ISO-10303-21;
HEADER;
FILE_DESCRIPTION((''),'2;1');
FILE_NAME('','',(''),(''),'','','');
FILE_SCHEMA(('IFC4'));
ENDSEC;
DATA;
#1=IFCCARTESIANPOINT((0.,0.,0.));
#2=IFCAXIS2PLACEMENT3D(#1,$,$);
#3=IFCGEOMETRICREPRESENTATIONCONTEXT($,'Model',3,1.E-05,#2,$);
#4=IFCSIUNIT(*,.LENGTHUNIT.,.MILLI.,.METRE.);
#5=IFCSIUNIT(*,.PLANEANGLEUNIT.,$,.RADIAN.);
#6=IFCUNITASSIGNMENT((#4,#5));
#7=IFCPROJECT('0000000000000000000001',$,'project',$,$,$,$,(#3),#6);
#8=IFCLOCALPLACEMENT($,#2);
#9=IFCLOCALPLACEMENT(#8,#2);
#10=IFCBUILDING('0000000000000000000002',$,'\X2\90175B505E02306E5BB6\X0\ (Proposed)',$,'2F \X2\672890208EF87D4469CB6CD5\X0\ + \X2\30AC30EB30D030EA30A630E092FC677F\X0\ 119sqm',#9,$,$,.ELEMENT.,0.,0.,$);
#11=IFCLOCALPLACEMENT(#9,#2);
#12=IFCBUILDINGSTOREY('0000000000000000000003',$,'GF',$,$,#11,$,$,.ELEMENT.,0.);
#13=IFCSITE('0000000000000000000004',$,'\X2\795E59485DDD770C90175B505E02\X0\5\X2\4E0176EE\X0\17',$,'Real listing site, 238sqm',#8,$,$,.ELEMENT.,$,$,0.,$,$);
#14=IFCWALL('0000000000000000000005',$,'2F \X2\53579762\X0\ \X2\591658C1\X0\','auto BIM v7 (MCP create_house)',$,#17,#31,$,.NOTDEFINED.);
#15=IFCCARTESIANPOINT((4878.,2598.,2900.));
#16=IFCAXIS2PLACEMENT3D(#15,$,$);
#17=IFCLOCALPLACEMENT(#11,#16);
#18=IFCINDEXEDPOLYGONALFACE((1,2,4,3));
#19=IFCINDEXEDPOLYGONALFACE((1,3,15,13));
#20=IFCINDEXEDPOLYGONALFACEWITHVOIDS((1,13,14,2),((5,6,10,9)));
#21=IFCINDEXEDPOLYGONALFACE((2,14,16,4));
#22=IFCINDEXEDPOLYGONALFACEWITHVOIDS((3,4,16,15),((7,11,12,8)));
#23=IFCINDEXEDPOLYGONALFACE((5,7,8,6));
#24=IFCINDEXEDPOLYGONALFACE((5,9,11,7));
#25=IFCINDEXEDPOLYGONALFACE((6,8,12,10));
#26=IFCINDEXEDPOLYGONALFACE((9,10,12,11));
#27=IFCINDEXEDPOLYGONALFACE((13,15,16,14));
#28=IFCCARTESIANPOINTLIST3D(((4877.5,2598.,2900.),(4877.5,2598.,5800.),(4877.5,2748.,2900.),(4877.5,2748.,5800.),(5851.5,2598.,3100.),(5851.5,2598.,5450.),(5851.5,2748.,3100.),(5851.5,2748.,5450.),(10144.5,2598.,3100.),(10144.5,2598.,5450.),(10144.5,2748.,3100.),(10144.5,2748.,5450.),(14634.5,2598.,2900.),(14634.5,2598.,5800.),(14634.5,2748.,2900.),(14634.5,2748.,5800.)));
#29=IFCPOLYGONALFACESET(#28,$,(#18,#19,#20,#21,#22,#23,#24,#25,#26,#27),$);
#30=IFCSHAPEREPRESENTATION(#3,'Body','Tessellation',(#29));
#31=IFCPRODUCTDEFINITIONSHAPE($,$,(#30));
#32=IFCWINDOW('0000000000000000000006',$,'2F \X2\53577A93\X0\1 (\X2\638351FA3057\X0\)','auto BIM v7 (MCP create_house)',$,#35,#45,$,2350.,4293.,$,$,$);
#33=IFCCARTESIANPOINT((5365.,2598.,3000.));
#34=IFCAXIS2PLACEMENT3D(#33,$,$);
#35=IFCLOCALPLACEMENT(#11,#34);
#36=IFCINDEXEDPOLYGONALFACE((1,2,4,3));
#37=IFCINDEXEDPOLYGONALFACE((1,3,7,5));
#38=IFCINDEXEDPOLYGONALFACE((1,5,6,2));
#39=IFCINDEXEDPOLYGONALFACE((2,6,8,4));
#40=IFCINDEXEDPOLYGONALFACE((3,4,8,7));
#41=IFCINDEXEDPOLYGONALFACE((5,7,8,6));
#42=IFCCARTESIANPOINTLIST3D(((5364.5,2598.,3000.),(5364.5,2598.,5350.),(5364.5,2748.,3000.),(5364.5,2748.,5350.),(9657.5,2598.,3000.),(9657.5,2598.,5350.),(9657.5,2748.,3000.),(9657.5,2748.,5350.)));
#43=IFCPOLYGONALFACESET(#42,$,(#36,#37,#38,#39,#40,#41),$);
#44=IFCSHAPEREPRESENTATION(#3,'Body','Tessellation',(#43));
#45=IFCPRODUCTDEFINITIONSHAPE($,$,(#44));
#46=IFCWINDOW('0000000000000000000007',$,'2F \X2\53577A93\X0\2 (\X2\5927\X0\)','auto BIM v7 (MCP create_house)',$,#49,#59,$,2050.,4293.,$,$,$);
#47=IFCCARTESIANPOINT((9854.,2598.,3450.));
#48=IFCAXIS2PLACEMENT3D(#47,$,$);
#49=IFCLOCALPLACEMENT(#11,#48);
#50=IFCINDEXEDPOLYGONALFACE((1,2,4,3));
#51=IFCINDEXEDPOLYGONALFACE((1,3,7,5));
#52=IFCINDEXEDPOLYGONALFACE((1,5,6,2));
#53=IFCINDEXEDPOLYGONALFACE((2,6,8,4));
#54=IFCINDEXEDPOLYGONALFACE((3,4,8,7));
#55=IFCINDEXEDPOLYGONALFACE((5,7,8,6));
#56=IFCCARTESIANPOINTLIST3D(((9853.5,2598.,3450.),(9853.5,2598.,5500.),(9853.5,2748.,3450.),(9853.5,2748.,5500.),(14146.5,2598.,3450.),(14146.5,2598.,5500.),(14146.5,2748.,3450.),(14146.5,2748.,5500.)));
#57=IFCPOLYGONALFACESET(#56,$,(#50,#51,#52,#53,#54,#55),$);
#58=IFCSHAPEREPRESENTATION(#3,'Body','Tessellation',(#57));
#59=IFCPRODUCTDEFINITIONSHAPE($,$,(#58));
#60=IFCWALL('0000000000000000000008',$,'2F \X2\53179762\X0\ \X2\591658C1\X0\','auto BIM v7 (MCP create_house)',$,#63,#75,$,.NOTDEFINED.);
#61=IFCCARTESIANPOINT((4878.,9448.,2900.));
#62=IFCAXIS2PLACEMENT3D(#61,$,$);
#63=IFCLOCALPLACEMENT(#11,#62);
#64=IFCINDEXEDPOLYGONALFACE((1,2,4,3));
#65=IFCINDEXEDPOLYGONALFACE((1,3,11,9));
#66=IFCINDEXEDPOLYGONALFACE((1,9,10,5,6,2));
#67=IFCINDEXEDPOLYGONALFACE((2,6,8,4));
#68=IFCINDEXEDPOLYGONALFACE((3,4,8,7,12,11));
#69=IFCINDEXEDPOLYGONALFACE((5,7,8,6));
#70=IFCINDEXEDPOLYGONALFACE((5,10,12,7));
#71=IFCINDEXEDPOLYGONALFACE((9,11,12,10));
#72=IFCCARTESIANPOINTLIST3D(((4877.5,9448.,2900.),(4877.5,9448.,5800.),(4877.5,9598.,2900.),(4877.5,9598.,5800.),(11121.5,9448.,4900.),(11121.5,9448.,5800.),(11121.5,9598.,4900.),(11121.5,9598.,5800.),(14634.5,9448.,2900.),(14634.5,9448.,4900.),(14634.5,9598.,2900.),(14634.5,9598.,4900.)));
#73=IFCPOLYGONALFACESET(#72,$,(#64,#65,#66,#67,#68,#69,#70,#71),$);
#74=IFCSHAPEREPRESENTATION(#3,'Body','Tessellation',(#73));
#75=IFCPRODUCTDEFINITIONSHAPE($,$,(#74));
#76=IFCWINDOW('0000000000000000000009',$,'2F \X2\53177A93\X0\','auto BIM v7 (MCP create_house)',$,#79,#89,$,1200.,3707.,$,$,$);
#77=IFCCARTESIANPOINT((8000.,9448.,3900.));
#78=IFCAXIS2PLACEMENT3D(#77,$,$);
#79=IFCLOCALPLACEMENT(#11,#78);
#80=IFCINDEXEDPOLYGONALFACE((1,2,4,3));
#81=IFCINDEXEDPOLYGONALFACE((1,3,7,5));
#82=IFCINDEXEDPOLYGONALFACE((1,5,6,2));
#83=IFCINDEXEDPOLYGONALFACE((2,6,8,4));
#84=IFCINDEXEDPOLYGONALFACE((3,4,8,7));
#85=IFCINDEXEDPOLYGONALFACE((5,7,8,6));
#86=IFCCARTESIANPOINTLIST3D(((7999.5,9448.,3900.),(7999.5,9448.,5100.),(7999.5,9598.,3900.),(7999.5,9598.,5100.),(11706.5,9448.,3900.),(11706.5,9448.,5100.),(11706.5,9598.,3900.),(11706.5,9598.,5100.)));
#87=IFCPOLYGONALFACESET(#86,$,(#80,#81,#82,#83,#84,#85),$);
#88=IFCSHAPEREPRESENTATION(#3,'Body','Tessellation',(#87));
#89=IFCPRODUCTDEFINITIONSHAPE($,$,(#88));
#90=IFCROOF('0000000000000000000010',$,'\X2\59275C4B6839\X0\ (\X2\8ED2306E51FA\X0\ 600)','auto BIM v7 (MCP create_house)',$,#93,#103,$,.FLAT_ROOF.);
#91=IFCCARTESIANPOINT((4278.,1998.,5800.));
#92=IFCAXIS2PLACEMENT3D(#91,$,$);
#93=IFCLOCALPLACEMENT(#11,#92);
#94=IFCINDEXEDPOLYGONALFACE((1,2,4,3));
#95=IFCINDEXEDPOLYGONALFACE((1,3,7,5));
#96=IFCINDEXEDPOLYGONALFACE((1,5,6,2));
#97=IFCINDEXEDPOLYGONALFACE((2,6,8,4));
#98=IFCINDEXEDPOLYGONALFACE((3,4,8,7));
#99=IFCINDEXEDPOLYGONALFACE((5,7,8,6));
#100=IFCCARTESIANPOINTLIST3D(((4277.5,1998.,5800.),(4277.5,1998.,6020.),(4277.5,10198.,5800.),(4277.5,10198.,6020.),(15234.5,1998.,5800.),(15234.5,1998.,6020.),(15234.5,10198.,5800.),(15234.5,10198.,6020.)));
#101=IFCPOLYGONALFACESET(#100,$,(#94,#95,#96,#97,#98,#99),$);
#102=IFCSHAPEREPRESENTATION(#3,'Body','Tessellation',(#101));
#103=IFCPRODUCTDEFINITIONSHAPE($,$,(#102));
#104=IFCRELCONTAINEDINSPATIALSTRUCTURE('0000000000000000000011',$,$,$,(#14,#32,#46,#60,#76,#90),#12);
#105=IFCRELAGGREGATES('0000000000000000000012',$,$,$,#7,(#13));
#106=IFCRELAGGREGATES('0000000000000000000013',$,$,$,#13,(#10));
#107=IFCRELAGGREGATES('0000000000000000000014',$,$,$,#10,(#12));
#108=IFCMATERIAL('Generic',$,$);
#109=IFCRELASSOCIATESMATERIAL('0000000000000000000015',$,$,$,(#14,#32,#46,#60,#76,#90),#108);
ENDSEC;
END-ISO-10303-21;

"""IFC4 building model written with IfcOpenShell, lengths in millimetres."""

from ifc_helpers import new_model, si_unit, frame, frame_2d, origin, place, context, project, spatial, rectangle, extrude, material, element, fill, save


model = new_model("IFC4")

# Units and contexts
model_context = context("Model", 3, precision=1e-05, world=origin())
ifc_project = project(units=[si_unit("LENGTHUNIT", "METRE", prefix="MILLI"), si_unit("PLANEANGLEUNIT", "RADIAN")], contexts=[model_context])

# Site, building, storey
site_placement = place(None, origin())
site = spatial("IfcSite", under=ifc_project, at=site_placement, Name="神奈川県逗子市5丁目17", ObjectType="Real listing site, 238sqm", CompositionType="ELEMENT", RefElevation=0.0)
building_placement = place(site_placement, origin())
building = spatial("IfcBuilding", under=site, at=building_placement, Name="逗子市の家 (Proposed)", ObjectType="2F 木造軸組構法 + ガルバリウム鋼板 119sqm", CompositionType="ELEMENT", ElevationOfRefHeight=0.0, ElevationOfTerrain=0.0)
storey_placement = place(building_placement, origin())
storey = spatial("IfcBuildingStorey", under=building, at=storey_placement, Name="GF", CompositionType="ELEMENT", Elevation=0.0)

# Shared definitions
ifc_material = material(Name="Generic")

# Wall, openings, windows
wall_1_placement = place(storey_placement, frame((4878.0, 2598.0, 2900.0)))
wall_1 = element("IfcWall", 1, at=wall_1_placement, inside=storey, material=ifc_material, Name="2F 南面 外壁", Description="auto BIM v7 (MCP create_house)", PredefinedType="NOTDEFINED", context=model_context, shape_type="SweptSolid", body=[
    extrude(rectangle(XDim=9757.0, YDim=150.0, at=frame_2d((4878.0, 75.0))), frame((4878.0, 2598.0, 2900.0)), (0.0, 0.0, 1.0), 2900.0),
])
opening_1_placement = place(storey_placement, frame((5365.0, 2598.0, 3000.0)))
opening_1 = element("IfcOpeningElement", 2, at=opening_1_placement, cuts=wall_1, PredefinedType="NOTDEFINED", context=model_context, shape_type="SweptSolid", body=[
    extrude(rectangle(XDim=4293.0, YDim=150.0, at=frame_2d((2146.0, 75.0))), frame((5365.0, 2598.0, 3000.0)), (0.0, 0.0, 1.0), 2350.0),
])
opening_2_placement = place(storey_placement, frame((9854.0, 2598.0, 3450.0)))
opening_2 = element("IfcOpeningElement", 3, at=opening_2_placement, cuts=wall_1, PredefinedType="NOTDEFINED", context=model_context, shape_type="SweptSolid", body=[
    extrude(rectangle(XDim=4293.0, YDim=150.0, at=frame_2d((2146.0, 75.0))), frame((9854.0, 2598.0, 3450.0)), (0.0, 0.0, 1.0), 2050.0),
])
window_1_placement = place(storey_placement, frame((5365.0, 2598.0, 3000.0)))
window_1 = element("IfcWindow", 4, at=window_1_placement, inside=storey, material=ifc_material, Name="2F 南窓1 (掃出し)", Description="auto BIM v7 (MCP create_house)", OverallHeight=2350.0, OverallWidth=4293.0, context=model_context, shape_type="SweptSolid", body=[
    extrude(rectangle(XDim=4293.0, YDim=150.0, at=frame_2d((2146.0, 75.0))), frame((5365.0, 2598.0, 3000.0)), (0.0, 0.0, 1.0), 2350.0),
])
fill(opening_1, window_1)
window_2_placement = place(storey_placement, frame((9854.0, 2598.0, 3450.0)))
window_2 = element("IfcWindow", 5, at=window_2_placement, inside=storey, material=ifc_material, Name="2F 南窓2 (大)", Description="auto BIM v7 (MCP create_house)", OverallHeight=2050.0, OverallWidth=4293.0, context=model_context, shape_type="SweptSolid", body=[
    extrude(rectangle(XDim=4293.0, YDim=150.0, at=frame_2d((2146.0, 75.0))), frame((9854.0, 2598.0, 3450.0)), (0.0, 0.0, 1.0), 2050.0),
])
fill(opening_2, window_2)

# Wall, opening, window
wall_2_placement = place(storey_placement, frame((4878.0, 9448.0, 2900.0)))
wall_2 = element("IfcWall", 6, at=wall_2_placement, inside=storey, material=ifc_material, Name="2F 北面 外壁", Description="auto BIM v7 (MCP create_house)", PredefinedType="NOTDEFINED", context=model_context, shape_type="SweptSolid", body=[
    extrude(rectangle(XDim=9757.0, YDim=150.0, at=frame_2d((4878.0, 75.0))), frame((4878.0, 9448.0, 2900.0)), (0.0, 0.0, 1.0), 2900.0),
])
opening_3_placement = place(storey_placement, frame((8000.0, 9448.0, 3900.0)))
opening_3 = element("IfcOpeningElement", 7, at=opening_3_placement, cuts=wall_2, PredefinedType="NOTDEFINED", context=model_context, shape_type="SweptSolid", body=[
    extrude(rectangle(XDim=3707.0, YDim=150.0, at=frame_2d((1853.0, 75.0))), frame((8000.0, 9448.0, 3900.0)), (0.0, 0.0, 1.0), 1200.0),
])
window_3_placement = place(storey_placement, frame((8000.0, 9448.0, 3900.0)))
window_3 = element("IfcWindow", 8, at=window_3_placement, inside=storey, material=ifc_material, Name="2F 北窓", Description="auto BIM v7 (MCP create_house)", OverallHeight=1200.0, OverallWidth=3707.0, context=model_context, shape_type="SweptSolid", body=[
    extrude(rectangle(XDim=3707.0, YDim=150.0, at=frame_2d((1853.0, 75.0))), frame((8000.0, 9448.0, 3900.0)), (0.0, 0.0, 1.0), 1200.0),
])
fill(opening_3, window_3)

# Roof
roof_placement = place(storey_placement, frame((4278.0, 1998.0, 5800.0)))
element("IfcRoof", 9, at=roof_placement, inside=storey, material=ifc_material, Name="大屋根 (軒の出 600)", Description="auto BIM v7 (MCP create_house)", PredefinedType="FLAT_ROOF", context=model_context, shape_type="SweptSolid", body=[
    extrude(rectangle(XDim=10957.0, YDim=8200.0, at=frame_2d((5478.0, 4100.0))), frame((4278.0, 1998.0, 5800.0)), (0.0, 0.0, 1.0), 220.0),
])

save(model, "model.ifc")
